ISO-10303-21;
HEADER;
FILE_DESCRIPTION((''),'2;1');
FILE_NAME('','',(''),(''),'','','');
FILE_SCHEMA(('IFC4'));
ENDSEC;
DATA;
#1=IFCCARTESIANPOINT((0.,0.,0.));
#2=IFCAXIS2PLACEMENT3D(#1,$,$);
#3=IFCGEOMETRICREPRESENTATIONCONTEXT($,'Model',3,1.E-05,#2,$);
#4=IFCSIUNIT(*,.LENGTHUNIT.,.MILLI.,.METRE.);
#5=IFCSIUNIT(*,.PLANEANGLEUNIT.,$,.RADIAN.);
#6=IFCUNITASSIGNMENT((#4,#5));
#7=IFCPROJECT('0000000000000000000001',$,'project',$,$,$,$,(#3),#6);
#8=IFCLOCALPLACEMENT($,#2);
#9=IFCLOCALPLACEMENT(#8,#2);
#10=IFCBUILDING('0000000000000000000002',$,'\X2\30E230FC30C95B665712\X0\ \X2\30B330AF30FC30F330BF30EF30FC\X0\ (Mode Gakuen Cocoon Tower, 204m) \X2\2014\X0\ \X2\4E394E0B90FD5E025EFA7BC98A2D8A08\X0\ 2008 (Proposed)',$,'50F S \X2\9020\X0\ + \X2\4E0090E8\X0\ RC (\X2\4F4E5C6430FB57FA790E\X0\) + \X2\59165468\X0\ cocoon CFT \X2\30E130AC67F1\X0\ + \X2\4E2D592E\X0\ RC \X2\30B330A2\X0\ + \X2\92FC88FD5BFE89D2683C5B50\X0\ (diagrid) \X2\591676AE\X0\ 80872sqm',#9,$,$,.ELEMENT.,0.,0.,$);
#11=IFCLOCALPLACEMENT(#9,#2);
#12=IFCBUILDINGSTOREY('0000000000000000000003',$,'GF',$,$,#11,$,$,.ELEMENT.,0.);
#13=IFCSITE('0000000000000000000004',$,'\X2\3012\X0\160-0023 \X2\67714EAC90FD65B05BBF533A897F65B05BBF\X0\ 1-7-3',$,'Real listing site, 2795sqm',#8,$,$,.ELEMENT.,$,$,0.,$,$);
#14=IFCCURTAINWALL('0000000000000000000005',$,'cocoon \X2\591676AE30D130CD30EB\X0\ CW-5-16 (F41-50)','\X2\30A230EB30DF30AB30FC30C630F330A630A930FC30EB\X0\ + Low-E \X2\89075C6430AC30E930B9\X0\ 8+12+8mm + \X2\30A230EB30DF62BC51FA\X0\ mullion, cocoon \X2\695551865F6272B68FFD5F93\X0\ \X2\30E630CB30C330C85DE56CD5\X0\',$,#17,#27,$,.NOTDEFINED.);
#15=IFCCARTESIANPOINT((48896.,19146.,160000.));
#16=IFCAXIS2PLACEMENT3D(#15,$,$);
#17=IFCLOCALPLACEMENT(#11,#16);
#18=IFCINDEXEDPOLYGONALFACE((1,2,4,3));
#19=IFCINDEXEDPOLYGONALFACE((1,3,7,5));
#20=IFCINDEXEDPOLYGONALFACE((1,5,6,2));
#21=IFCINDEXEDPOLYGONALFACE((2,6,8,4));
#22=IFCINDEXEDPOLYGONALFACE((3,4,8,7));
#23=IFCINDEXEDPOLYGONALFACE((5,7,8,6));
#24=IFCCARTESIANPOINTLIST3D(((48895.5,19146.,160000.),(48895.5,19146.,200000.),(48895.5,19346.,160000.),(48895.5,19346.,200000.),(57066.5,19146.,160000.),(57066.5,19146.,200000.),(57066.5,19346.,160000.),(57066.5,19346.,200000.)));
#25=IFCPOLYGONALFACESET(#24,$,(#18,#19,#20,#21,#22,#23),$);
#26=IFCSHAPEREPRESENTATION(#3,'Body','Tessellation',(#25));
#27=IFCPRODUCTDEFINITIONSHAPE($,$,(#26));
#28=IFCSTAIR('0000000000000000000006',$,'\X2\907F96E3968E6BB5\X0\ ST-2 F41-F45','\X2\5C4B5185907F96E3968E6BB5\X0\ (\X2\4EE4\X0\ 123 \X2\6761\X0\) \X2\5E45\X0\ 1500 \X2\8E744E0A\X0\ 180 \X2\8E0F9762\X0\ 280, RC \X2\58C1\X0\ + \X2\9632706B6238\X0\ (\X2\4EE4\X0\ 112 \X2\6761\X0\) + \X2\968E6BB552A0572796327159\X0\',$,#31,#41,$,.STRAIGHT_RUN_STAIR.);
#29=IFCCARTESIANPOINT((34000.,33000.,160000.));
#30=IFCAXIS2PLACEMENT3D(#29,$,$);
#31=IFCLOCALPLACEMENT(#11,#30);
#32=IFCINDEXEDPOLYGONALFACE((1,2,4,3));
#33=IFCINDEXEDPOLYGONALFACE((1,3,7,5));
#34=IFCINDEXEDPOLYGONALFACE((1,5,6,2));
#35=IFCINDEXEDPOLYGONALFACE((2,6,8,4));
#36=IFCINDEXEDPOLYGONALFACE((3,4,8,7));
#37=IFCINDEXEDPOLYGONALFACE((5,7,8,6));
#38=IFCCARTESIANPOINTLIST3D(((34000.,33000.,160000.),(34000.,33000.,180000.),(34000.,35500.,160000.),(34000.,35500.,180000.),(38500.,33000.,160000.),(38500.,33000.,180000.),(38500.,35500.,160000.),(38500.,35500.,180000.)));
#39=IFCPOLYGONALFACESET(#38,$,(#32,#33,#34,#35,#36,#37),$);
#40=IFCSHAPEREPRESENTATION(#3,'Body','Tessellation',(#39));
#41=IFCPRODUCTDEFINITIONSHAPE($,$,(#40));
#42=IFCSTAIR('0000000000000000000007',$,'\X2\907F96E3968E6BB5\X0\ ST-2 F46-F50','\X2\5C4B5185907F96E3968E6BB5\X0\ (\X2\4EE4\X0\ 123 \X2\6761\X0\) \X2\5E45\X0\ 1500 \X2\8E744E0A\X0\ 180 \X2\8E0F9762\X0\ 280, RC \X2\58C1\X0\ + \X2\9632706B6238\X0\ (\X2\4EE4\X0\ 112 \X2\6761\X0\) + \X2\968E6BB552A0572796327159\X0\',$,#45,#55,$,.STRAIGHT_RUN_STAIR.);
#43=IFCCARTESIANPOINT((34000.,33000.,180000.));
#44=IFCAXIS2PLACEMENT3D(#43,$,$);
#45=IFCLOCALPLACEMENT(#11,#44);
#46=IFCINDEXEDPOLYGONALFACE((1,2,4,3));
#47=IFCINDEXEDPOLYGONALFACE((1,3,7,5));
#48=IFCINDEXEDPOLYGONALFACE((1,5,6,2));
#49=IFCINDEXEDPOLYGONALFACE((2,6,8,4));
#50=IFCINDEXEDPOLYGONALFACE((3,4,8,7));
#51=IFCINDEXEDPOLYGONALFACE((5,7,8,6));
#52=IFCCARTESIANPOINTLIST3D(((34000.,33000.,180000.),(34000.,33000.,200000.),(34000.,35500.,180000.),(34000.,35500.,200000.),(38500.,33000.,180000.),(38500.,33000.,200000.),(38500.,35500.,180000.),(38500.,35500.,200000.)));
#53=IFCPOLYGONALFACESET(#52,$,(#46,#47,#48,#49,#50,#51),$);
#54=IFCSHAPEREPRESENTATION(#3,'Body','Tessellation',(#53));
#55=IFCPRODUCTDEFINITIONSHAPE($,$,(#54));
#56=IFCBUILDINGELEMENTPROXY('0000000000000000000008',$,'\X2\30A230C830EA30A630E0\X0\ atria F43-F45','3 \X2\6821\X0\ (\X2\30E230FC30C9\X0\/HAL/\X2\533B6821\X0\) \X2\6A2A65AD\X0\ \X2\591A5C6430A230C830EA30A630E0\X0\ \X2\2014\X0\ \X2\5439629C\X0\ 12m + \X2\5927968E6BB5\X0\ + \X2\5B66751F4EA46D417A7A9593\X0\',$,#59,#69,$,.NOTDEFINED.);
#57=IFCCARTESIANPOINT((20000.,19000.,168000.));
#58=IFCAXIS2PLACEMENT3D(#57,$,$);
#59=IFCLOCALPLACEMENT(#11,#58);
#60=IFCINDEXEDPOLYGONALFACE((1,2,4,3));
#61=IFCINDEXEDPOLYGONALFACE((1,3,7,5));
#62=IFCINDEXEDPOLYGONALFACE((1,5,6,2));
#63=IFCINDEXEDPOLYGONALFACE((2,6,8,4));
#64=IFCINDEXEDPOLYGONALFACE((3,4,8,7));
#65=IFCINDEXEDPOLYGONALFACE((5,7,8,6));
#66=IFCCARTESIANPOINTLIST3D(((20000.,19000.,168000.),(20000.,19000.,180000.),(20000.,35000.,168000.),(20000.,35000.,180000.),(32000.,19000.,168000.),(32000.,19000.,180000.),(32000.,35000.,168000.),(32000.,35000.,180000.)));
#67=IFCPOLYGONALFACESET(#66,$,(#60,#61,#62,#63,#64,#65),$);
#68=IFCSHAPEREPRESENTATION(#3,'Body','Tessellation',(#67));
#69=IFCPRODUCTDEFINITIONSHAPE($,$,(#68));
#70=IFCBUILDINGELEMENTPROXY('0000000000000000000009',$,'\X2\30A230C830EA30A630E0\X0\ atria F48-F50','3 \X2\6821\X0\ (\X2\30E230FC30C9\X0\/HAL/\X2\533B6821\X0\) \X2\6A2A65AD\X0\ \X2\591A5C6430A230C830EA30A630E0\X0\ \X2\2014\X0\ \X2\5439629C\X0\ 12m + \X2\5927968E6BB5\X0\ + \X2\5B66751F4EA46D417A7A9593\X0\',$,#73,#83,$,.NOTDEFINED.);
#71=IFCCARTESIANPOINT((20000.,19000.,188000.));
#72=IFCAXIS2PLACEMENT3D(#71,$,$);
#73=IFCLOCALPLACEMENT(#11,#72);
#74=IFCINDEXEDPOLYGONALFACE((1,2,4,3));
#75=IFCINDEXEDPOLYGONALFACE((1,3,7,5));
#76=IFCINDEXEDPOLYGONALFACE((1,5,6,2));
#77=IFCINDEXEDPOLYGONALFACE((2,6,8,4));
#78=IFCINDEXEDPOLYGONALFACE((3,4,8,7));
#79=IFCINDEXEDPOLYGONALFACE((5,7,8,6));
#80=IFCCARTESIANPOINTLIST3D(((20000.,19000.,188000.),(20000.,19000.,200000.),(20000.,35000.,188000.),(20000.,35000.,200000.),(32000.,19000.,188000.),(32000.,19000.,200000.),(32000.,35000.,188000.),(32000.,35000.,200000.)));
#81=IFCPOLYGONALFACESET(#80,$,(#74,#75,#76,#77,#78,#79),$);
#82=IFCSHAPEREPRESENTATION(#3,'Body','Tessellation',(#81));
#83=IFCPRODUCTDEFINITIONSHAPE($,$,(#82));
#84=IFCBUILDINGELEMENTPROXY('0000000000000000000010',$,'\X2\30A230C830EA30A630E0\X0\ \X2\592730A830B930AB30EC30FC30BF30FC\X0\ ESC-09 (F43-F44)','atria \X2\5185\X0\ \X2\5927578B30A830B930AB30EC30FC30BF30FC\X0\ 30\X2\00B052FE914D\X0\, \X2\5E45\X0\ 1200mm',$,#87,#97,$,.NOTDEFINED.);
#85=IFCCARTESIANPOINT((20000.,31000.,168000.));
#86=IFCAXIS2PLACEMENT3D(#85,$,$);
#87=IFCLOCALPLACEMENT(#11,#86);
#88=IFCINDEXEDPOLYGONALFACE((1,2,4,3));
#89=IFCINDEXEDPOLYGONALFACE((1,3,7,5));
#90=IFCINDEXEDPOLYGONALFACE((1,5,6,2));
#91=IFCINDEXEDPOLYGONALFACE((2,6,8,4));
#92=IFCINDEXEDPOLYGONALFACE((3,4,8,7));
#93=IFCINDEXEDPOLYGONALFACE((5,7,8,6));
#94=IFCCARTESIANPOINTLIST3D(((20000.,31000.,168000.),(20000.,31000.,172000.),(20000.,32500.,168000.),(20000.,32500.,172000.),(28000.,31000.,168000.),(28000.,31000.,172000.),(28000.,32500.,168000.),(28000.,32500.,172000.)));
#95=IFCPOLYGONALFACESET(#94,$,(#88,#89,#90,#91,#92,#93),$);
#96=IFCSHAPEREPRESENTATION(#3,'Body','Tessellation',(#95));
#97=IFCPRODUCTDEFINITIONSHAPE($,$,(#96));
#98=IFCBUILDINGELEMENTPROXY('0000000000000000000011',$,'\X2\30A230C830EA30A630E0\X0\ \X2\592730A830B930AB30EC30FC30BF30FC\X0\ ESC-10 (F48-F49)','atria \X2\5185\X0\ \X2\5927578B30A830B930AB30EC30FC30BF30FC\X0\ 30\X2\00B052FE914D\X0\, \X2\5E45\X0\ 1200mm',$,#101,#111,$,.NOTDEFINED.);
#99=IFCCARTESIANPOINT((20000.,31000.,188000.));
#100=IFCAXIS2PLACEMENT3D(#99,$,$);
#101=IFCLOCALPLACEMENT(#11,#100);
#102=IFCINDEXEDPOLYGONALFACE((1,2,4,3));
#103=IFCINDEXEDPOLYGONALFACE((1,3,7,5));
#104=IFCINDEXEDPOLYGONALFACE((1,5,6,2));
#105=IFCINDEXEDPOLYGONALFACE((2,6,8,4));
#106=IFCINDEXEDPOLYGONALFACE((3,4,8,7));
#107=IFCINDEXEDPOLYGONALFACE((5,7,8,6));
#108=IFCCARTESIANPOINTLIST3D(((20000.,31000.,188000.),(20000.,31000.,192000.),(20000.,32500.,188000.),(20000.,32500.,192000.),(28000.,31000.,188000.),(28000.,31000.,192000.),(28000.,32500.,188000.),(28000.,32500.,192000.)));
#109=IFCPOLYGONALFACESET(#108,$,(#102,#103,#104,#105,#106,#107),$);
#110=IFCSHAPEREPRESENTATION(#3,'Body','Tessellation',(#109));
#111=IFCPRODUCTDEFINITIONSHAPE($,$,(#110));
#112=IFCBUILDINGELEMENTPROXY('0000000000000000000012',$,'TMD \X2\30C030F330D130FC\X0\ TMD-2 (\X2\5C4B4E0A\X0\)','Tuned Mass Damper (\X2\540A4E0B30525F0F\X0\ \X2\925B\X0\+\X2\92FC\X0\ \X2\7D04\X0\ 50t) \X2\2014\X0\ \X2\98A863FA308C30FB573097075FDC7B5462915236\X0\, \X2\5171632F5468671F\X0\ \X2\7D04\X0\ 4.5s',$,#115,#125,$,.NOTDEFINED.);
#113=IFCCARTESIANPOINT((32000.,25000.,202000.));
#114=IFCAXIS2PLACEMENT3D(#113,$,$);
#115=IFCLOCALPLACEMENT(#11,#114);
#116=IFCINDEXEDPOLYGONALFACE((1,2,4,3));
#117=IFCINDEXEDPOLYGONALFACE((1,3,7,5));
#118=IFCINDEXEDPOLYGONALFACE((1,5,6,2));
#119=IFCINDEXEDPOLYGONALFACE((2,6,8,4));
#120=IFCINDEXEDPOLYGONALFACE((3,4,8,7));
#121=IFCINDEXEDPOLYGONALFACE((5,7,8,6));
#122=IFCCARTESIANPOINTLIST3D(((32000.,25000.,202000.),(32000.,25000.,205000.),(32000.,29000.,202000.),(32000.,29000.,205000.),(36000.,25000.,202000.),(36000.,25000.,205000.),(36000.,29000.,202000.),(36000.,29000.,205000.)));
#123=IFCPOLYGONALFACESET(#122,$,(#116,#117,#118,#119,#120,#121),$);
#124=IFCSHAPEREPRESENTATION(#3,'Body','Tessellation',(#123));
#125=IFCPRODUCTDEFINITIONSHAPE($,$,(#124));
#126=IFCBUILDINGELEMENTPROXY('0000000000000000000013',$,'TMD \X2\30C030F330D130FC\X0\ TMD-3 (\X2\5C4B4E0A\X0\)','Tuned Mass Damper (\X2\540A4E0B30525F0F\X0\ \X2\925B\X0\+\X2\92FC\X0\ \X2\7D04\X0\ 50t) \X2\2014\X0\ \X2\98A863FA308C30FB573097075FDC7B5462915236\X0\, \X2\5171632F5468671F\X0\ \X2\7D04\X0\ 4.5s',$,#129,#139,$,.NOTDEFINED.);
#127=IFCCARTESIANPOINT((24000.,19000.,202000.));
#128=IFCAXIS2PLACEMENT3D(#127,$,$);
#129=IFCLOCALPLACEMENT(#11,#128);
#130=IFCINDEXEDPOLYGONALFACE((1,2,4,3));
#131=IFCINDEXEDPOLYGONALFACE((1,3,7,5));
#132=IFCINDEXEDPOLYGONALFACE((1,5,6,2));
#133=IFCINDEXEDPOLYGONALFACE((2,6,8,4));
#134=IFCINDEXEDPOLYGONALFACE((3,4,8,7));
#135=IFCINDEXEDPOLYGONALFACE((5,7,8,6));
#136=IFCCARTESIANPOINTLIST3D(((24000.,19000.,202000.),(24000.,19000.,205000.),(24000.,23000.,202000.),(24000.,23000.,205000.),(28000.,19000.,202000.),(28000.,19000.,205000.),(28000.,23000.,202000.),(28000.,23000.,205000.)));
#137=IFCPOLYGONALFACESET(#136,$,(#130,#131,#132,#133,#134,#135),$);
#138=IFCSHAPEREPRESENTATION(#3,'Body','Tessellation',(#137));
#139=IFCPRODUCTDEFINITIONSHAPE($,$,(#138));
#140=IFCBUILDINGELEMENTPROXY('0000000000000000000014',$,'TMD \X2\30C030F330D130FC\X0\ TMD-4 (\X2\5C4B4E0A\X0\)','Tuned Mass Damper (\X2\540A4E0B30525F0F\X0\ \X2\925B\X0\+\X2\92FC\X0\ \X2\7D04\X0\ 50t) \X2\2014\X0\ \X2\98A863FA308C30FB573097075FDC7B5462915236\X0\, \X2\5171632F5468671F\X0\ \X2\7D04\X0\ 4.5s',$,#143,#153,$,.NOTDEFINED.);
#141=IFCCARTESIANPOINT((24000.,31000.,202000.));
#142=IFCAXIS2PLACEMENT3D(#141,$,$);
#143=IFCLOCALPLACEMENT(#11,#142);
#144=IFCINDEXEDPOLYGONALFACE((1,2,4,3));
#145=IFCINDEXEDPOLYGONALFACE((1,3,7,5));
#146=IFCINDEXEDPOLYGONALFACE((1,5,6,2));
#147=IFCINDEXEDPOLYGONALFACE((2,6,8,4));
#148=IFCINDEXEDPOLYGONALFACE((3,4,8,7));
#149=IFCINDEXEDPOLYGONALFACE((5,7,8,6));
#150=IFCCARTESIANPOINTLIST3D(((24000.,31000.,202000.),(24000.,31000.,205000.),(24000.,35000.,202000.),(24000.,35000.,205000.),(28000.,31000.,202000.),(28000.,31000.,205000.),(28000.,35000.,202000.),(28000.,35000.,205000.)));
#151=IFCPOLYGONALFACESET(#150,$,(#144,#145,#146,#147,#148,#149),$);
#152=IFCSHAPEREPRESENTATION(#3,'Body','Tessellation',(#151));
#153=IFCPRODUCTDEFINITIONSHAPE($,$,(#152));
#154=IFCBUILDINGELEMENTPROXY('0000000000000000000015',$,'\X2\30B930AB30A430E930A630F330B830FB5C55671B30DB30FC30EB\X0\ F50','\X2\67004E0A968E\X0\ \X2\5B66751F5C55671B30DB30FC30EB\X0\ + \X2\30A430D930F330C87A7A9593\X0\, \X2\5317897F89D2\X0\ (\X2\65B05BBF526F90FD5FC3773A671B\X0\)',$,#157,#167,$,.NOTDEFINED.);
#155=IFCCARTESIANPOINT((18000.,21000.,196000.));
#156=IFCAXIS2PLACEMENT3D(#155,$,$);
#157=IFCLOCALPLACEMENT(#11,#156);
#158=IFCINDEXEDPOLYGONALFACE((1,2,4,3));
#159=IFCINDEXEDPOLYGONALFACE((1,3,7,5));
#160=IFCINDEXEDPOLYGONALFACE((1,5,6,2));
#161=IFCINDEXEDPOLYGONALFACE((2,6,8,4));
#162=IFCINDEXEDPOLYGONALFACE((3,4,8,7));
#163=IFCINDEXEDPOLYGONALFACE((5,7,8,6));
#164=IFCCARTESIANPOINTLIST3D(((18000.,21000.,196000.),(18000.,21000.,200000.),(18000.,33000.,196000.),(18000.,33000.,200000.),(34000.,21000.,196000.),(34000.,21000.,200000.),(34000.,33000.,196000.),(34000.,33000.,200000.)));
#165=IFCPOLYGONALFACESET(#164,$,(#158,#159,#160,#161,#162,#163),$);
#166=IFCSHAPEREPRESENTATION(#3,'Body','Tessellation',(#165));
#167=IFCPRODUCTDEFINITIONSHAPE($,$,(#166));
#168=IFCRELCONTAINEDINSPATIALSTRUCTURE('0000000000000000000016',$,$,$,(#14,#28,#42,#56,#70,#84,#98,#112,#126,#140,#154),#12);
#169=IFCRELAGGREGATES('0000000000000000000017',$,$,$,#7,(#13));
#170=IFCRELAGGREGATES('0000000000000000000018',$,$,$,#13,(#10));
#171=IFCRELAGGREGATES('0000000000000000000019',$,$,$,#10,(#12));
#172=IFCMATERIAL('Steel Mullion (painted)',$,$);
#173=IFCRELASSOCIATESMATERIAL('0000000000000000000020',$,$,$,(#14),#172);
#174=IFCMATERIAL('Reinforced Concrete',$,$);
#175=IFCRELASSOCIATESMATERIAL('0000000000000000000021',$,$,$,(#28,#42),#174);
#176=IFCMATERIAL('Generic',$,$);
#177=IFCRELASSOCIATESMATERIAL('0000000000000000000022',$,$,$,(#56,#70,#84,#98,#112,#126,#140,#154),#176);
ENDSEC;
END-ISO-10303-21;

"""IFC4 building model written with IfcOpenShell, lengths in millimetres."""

from ifc_helpers import new_model, si_unit, frame, frame_2d, origin, place, context, project, spatial, rectangle, extrude, material, element, save


model = new_model("IFC4")

# Units and contexts
model_context = context("Model", 3, precision=1e-05, world=origin())
ifc_project = project(units=[si_unit("LENGTHUNIT", "METRE", prefix="MILLI"), si_unit("PLANEANGLEUNIT", "RADIAN")], contexts=[model_context])

# Site, building, storey
site_placement = place(None, origin())
site = spatial("IfcSite", under=ifc_project, at=site_placement, Name="〒160-0023 東京都新宿区西新宿 1-7-3", ObjectType="Real listing site, 2795sqm", CompositionType="ELEMENT", RefElevation=0.0)
building_placement = place(site_placement, origin())
building = spatial("IfcBuilding", under=site, at=building_placement, Name="モード学園 コクーンタワー (Mode Gakuen Cocoon Tower, 204m) — 丹下都市建築設計 2008 (Proposed)", ObjectType="50F S 造 + 一部 RC (低層・基礎) + 外周 cocoon CFT メガ柱 + 中央 RC コア + 鋼製対角格子 (diagrid) 外皮 80872sqm", CompositionType="ELEMENT", ElevationOfRefHeight=0.0, ElevationOfTerrain=0.0)
storey_placement = place(building_placement, origin())
storey = spatial("IfcBuildingStorey", under=building, at=storey_placement, Name="GF", CompositionType="ELEMENT", Elevation=0.0)

# Shared definitions
ifc_material_1 = material(Name="Generic")

# Curtain wall
ifc_material_2 = material(Name="Steel Mullion (painted)")
curtain_wall_1_placement = place(storey_placement, frame((48896.0, 19146.0, 160000.0)))
element("IfcCurtainWall", 1, at=curtain_wall_1_placement, inside=storey, material=ifc_material_2, Name="cocoon 外皮パネル CW-5-16 (F41-50)", Description="アルミカーテンウォール + Low-E 複層ガラス 8+12+8mm + アルミ押出 mullion, cocoon 楕円形状追従 ユニット工法", PredefinedType="NOTDEFINED", context=model_context, shape_type="SweptSolid", body=[
    extrude(rectangle(XDim=8171.0, YDim=200.0, at=frame_2d((4085.0, 100.0))), frame((48896.0, 19146.0, 160000.0)), (0.0, 0.0, 1.0), 40000.0),
])

# Stairs
ifc_material_3 = material(Name="Reinforced Concrete")
stair_1_placement = place(storey_placement, frame((34000.0, 33000.0, 160000.0)))
element("IfcStair", 2, at=stair_1_placement, inside=storey, material=ifc_material_3, Name="避難階段 ST-2 F41-F45", Description="屋内避難階段 (令 123 条) 幅 1500 蹴上 180 踏面 280, RC 壁 + 防火戸 (令 112 条) + 階段加圧防煙", PredefinedType="STRAIGHT_RUN_STAIR", context=model_context, shape_type="SweptSolid", body=[
    extrude(rectangle(XDim=4500.0, YDim=2500.0, at=frame_2d((2250.0, 1250.0))), frame((34000.0, 33000.0, 160000.0)), (0.0, 0.0, 1.0), 20000.0),
])
stair_2_placement = place(storey_placement, frame((34000.0, 33000.0, 180000.0)))
element("IfcStair", 3, at=stair_2_placement, inside=storey, material=ifc_material_3, Name="避難階段 ST-2 F46-F50", Description="屋内避難階段 (令 123 条) 幅 1500 蹴上 180 踏面 280, RC 壁 + 防火戸 (令 112 条) + 階段加圧防煙", PredefinedType="STRAIGHT_RUN_STAIR", context=model_context, shape_type="SweptSolid", body=[
    extrude(rectangle(XDim=4500.0, YDim=2500.0, at=frame_2d((2250.0, 1250.0))), frame((34000.0, 33000.0, 180000.0)), (0.0, 0.0, 1.0), 20000.0),
])

# Building element proxies
proxy_1_placement = place(storey_placement, frame((20000.0, 19000.0, 168000.0)))
element("IfcBuildingElementProxy", 4, at=proxy_1_placement, inside=storey, material=ifc_material_1, Name="アトリウム atria F43-F45", Description="3 校 (モード/HAL/医校) 横断 多層アトリウム — 吹抜 12m + 大階段 + 学生交流空間", PredefinedType="NOTDEFINED", context=model_context, shape_type="SweptSolid", body=[
    extrude(rectangle(XDim=12000.0, YDim=16000.0, at=frame_2d((6000.0, 8000.0))), frame((20000.0, 19000.0, 168000.0)), (0.0, 0.0, 1.0), 12000.0),
])
proxy_2_placement = place(storey_placement, frame((20000.0, 19000.0, 188000.0)))
element("IfcBuildingElementProxy", 5, at=proxy_2_placement, inside=storey, material=ifc_material_1, Name="アトリウム atria F48-F50", Description="3 校 (モード/HAL/医校) 横断 多層アトリウム — 吹抜 12m + 大階段 + 学生交流空間", PredefinedType="NOTDEFINED", context=model_context, shape_type="SweptSolid", body=[
    extrude(rectangle(XDim=12000.0, YDim=16000.0, at=frame_2d((6000.0, 8000.0))), frame((20000.0, 19000.0, 188000.0)), (0.0, 0.0, 1.0), 12000.0),
])
proxy_3_placement = place(storey_placement, frame((20000.0, 31000.0, 168000.0)))
element("IfcBuildingElementProxy", 6, at=proxy_3_placement, inside=storey, material=ifc_material_1, Name="アトリウム 大エスカレーター ESC-09 (F43-F44)", Description="atria 内 大型エスカレーター 30°勾配, 幅 1200mm", PredefinedType="NOTDEFINED", context=model_context, shape_type="SweptSolid", body=[
    extrude(rectangle(XDim=8000.0, YDim=1500.0, at=frame_2d((4000.0, 750.0))), frame((20000.0, 31000.0, 168000.0)), (0.0, 0.0, 1.0), 4000.0),
])
proxy_4_placement = place(storey_placement, frame((20000.0, 31000.0, 188000.0)))
element("IfcBuildingElementProxy", 7, at=proxy_4_placement, inside=storey, material=ifc_material_1, Name="アトリウム 大エスカレーター ESC-10 (F48-F49)", Description="atria 内 大型エスカレーター 30°勾配, 幅 1200mm", PredefinedType="NOTDEFINED", context=model_context, shape_type="SweptSolid", body=[
    extrude(rectangle(XDim=8000.0, YDim=1500.0, at=frame_2d((4000.0, 750.0))), frame((20000.0, 31000.0, 188000.0)), (0.0, 0.0, 1.0), 4000.0),
])
proxy_5_placement = place(storey_placement, frame((32000.0, 25000.0, 202000.0)))
element("IfcBuildingElementProxy", 8, at=proxy_5_placement, inside=storey, material=ifc_material_1, Name="TMD ダンパー TMD-2 (屋上)", Description="Tuned Mass Damper (吊下げ式 鉛+鋼 約 50t) — 風揺れ・地震応答抑制, 共振周期 約 4.5s", PredefinedType="NOTDEFINED", context=model_context, shape_type="SweptSolid", body=[
    extrude(rectangle(XDim=4000.0, YDim=4000.0, at=frame_2d((2000.0, 2000.0))), frame((32000.0, 25000.0, 202000.0)), (0.0, 0.0, 1.0), 3000.0),
])
proxy_6_placement = place(storey_placement, frame((24000.0, 19000.0, 202000.0)))
element("IfcBuildingElementProxy", 9, at=proxy_6_placement, inside=storey, material=ifc_material_1, Name="TMD ダンパー TMD-3 (屋上)", Description="Tuned Mass Damper (吊下げ式 鉛+鋼 約 50t) — 風揺れ・地震応答抑制, 共振周期 約 4.5s", PredefinedType="NOTDEFINED", context=model_context, shape_type="SweptSolid", body=[
    extrude(rectangle(XDim=4000.0, YDim=4000.0, at=frame_2d((2000.0, 2000.0))), frame((24000.0, 19000.0, 202000.0)), (0.0, 0.0, 1.0), 3000.0),
])
proxy_7_placement = place(storey_placement, frame((24000.0, 31000.0, 202000.0)))
element("IfcBuildingElementProxy", 10, at=proxy_7_placement, inside=storey, material=ifc_material_1, Name="TMD ダンパー TMD-4 (屋上)", Description="Tuned Mass Damper (吊下げ式 鉛+鋼 約 50t) — 風揺れ・地震応答抑制, 共振周期 約 4.5s", PredefinedType="NOTDEFINED", context=model_context, shape_type="SweptSolid", body=[
    extrude(rectangle(XDim=4000.0, YDim=4000.0, at=frame_2d((2000.0, 2000.0))), frame((24000.0, 31000.0, 202000.0)), (0.0, 0.0, 1.0), 3000.0),
])
proxy_8_placement = place(storey_placement, frame((18000.0, 21000.0, 196000.0)))
element("IfcBuildingElementProxy", 11, at=proxy_8_placement, inside=storey, material=ifc_material_1, Name="スカイラウンジ・展望ホール F50", Description="最上階 学生展望ホール + イベント空間, 北西角 (新宿副都心眺望)", PredefinedType="NOTDEFINED", context=model_context, shape_type="SweptSolid", body=[
    extrude(rectangle(XDim=16000.0, YDim=12000.0, at=frame_2d((8000.0, 6000.0))), frame((18000.0, 21000.0, 196000.0)), (0.0, 0.0, 1.0), 4000.0),
])

save(model, "model.ifc")
